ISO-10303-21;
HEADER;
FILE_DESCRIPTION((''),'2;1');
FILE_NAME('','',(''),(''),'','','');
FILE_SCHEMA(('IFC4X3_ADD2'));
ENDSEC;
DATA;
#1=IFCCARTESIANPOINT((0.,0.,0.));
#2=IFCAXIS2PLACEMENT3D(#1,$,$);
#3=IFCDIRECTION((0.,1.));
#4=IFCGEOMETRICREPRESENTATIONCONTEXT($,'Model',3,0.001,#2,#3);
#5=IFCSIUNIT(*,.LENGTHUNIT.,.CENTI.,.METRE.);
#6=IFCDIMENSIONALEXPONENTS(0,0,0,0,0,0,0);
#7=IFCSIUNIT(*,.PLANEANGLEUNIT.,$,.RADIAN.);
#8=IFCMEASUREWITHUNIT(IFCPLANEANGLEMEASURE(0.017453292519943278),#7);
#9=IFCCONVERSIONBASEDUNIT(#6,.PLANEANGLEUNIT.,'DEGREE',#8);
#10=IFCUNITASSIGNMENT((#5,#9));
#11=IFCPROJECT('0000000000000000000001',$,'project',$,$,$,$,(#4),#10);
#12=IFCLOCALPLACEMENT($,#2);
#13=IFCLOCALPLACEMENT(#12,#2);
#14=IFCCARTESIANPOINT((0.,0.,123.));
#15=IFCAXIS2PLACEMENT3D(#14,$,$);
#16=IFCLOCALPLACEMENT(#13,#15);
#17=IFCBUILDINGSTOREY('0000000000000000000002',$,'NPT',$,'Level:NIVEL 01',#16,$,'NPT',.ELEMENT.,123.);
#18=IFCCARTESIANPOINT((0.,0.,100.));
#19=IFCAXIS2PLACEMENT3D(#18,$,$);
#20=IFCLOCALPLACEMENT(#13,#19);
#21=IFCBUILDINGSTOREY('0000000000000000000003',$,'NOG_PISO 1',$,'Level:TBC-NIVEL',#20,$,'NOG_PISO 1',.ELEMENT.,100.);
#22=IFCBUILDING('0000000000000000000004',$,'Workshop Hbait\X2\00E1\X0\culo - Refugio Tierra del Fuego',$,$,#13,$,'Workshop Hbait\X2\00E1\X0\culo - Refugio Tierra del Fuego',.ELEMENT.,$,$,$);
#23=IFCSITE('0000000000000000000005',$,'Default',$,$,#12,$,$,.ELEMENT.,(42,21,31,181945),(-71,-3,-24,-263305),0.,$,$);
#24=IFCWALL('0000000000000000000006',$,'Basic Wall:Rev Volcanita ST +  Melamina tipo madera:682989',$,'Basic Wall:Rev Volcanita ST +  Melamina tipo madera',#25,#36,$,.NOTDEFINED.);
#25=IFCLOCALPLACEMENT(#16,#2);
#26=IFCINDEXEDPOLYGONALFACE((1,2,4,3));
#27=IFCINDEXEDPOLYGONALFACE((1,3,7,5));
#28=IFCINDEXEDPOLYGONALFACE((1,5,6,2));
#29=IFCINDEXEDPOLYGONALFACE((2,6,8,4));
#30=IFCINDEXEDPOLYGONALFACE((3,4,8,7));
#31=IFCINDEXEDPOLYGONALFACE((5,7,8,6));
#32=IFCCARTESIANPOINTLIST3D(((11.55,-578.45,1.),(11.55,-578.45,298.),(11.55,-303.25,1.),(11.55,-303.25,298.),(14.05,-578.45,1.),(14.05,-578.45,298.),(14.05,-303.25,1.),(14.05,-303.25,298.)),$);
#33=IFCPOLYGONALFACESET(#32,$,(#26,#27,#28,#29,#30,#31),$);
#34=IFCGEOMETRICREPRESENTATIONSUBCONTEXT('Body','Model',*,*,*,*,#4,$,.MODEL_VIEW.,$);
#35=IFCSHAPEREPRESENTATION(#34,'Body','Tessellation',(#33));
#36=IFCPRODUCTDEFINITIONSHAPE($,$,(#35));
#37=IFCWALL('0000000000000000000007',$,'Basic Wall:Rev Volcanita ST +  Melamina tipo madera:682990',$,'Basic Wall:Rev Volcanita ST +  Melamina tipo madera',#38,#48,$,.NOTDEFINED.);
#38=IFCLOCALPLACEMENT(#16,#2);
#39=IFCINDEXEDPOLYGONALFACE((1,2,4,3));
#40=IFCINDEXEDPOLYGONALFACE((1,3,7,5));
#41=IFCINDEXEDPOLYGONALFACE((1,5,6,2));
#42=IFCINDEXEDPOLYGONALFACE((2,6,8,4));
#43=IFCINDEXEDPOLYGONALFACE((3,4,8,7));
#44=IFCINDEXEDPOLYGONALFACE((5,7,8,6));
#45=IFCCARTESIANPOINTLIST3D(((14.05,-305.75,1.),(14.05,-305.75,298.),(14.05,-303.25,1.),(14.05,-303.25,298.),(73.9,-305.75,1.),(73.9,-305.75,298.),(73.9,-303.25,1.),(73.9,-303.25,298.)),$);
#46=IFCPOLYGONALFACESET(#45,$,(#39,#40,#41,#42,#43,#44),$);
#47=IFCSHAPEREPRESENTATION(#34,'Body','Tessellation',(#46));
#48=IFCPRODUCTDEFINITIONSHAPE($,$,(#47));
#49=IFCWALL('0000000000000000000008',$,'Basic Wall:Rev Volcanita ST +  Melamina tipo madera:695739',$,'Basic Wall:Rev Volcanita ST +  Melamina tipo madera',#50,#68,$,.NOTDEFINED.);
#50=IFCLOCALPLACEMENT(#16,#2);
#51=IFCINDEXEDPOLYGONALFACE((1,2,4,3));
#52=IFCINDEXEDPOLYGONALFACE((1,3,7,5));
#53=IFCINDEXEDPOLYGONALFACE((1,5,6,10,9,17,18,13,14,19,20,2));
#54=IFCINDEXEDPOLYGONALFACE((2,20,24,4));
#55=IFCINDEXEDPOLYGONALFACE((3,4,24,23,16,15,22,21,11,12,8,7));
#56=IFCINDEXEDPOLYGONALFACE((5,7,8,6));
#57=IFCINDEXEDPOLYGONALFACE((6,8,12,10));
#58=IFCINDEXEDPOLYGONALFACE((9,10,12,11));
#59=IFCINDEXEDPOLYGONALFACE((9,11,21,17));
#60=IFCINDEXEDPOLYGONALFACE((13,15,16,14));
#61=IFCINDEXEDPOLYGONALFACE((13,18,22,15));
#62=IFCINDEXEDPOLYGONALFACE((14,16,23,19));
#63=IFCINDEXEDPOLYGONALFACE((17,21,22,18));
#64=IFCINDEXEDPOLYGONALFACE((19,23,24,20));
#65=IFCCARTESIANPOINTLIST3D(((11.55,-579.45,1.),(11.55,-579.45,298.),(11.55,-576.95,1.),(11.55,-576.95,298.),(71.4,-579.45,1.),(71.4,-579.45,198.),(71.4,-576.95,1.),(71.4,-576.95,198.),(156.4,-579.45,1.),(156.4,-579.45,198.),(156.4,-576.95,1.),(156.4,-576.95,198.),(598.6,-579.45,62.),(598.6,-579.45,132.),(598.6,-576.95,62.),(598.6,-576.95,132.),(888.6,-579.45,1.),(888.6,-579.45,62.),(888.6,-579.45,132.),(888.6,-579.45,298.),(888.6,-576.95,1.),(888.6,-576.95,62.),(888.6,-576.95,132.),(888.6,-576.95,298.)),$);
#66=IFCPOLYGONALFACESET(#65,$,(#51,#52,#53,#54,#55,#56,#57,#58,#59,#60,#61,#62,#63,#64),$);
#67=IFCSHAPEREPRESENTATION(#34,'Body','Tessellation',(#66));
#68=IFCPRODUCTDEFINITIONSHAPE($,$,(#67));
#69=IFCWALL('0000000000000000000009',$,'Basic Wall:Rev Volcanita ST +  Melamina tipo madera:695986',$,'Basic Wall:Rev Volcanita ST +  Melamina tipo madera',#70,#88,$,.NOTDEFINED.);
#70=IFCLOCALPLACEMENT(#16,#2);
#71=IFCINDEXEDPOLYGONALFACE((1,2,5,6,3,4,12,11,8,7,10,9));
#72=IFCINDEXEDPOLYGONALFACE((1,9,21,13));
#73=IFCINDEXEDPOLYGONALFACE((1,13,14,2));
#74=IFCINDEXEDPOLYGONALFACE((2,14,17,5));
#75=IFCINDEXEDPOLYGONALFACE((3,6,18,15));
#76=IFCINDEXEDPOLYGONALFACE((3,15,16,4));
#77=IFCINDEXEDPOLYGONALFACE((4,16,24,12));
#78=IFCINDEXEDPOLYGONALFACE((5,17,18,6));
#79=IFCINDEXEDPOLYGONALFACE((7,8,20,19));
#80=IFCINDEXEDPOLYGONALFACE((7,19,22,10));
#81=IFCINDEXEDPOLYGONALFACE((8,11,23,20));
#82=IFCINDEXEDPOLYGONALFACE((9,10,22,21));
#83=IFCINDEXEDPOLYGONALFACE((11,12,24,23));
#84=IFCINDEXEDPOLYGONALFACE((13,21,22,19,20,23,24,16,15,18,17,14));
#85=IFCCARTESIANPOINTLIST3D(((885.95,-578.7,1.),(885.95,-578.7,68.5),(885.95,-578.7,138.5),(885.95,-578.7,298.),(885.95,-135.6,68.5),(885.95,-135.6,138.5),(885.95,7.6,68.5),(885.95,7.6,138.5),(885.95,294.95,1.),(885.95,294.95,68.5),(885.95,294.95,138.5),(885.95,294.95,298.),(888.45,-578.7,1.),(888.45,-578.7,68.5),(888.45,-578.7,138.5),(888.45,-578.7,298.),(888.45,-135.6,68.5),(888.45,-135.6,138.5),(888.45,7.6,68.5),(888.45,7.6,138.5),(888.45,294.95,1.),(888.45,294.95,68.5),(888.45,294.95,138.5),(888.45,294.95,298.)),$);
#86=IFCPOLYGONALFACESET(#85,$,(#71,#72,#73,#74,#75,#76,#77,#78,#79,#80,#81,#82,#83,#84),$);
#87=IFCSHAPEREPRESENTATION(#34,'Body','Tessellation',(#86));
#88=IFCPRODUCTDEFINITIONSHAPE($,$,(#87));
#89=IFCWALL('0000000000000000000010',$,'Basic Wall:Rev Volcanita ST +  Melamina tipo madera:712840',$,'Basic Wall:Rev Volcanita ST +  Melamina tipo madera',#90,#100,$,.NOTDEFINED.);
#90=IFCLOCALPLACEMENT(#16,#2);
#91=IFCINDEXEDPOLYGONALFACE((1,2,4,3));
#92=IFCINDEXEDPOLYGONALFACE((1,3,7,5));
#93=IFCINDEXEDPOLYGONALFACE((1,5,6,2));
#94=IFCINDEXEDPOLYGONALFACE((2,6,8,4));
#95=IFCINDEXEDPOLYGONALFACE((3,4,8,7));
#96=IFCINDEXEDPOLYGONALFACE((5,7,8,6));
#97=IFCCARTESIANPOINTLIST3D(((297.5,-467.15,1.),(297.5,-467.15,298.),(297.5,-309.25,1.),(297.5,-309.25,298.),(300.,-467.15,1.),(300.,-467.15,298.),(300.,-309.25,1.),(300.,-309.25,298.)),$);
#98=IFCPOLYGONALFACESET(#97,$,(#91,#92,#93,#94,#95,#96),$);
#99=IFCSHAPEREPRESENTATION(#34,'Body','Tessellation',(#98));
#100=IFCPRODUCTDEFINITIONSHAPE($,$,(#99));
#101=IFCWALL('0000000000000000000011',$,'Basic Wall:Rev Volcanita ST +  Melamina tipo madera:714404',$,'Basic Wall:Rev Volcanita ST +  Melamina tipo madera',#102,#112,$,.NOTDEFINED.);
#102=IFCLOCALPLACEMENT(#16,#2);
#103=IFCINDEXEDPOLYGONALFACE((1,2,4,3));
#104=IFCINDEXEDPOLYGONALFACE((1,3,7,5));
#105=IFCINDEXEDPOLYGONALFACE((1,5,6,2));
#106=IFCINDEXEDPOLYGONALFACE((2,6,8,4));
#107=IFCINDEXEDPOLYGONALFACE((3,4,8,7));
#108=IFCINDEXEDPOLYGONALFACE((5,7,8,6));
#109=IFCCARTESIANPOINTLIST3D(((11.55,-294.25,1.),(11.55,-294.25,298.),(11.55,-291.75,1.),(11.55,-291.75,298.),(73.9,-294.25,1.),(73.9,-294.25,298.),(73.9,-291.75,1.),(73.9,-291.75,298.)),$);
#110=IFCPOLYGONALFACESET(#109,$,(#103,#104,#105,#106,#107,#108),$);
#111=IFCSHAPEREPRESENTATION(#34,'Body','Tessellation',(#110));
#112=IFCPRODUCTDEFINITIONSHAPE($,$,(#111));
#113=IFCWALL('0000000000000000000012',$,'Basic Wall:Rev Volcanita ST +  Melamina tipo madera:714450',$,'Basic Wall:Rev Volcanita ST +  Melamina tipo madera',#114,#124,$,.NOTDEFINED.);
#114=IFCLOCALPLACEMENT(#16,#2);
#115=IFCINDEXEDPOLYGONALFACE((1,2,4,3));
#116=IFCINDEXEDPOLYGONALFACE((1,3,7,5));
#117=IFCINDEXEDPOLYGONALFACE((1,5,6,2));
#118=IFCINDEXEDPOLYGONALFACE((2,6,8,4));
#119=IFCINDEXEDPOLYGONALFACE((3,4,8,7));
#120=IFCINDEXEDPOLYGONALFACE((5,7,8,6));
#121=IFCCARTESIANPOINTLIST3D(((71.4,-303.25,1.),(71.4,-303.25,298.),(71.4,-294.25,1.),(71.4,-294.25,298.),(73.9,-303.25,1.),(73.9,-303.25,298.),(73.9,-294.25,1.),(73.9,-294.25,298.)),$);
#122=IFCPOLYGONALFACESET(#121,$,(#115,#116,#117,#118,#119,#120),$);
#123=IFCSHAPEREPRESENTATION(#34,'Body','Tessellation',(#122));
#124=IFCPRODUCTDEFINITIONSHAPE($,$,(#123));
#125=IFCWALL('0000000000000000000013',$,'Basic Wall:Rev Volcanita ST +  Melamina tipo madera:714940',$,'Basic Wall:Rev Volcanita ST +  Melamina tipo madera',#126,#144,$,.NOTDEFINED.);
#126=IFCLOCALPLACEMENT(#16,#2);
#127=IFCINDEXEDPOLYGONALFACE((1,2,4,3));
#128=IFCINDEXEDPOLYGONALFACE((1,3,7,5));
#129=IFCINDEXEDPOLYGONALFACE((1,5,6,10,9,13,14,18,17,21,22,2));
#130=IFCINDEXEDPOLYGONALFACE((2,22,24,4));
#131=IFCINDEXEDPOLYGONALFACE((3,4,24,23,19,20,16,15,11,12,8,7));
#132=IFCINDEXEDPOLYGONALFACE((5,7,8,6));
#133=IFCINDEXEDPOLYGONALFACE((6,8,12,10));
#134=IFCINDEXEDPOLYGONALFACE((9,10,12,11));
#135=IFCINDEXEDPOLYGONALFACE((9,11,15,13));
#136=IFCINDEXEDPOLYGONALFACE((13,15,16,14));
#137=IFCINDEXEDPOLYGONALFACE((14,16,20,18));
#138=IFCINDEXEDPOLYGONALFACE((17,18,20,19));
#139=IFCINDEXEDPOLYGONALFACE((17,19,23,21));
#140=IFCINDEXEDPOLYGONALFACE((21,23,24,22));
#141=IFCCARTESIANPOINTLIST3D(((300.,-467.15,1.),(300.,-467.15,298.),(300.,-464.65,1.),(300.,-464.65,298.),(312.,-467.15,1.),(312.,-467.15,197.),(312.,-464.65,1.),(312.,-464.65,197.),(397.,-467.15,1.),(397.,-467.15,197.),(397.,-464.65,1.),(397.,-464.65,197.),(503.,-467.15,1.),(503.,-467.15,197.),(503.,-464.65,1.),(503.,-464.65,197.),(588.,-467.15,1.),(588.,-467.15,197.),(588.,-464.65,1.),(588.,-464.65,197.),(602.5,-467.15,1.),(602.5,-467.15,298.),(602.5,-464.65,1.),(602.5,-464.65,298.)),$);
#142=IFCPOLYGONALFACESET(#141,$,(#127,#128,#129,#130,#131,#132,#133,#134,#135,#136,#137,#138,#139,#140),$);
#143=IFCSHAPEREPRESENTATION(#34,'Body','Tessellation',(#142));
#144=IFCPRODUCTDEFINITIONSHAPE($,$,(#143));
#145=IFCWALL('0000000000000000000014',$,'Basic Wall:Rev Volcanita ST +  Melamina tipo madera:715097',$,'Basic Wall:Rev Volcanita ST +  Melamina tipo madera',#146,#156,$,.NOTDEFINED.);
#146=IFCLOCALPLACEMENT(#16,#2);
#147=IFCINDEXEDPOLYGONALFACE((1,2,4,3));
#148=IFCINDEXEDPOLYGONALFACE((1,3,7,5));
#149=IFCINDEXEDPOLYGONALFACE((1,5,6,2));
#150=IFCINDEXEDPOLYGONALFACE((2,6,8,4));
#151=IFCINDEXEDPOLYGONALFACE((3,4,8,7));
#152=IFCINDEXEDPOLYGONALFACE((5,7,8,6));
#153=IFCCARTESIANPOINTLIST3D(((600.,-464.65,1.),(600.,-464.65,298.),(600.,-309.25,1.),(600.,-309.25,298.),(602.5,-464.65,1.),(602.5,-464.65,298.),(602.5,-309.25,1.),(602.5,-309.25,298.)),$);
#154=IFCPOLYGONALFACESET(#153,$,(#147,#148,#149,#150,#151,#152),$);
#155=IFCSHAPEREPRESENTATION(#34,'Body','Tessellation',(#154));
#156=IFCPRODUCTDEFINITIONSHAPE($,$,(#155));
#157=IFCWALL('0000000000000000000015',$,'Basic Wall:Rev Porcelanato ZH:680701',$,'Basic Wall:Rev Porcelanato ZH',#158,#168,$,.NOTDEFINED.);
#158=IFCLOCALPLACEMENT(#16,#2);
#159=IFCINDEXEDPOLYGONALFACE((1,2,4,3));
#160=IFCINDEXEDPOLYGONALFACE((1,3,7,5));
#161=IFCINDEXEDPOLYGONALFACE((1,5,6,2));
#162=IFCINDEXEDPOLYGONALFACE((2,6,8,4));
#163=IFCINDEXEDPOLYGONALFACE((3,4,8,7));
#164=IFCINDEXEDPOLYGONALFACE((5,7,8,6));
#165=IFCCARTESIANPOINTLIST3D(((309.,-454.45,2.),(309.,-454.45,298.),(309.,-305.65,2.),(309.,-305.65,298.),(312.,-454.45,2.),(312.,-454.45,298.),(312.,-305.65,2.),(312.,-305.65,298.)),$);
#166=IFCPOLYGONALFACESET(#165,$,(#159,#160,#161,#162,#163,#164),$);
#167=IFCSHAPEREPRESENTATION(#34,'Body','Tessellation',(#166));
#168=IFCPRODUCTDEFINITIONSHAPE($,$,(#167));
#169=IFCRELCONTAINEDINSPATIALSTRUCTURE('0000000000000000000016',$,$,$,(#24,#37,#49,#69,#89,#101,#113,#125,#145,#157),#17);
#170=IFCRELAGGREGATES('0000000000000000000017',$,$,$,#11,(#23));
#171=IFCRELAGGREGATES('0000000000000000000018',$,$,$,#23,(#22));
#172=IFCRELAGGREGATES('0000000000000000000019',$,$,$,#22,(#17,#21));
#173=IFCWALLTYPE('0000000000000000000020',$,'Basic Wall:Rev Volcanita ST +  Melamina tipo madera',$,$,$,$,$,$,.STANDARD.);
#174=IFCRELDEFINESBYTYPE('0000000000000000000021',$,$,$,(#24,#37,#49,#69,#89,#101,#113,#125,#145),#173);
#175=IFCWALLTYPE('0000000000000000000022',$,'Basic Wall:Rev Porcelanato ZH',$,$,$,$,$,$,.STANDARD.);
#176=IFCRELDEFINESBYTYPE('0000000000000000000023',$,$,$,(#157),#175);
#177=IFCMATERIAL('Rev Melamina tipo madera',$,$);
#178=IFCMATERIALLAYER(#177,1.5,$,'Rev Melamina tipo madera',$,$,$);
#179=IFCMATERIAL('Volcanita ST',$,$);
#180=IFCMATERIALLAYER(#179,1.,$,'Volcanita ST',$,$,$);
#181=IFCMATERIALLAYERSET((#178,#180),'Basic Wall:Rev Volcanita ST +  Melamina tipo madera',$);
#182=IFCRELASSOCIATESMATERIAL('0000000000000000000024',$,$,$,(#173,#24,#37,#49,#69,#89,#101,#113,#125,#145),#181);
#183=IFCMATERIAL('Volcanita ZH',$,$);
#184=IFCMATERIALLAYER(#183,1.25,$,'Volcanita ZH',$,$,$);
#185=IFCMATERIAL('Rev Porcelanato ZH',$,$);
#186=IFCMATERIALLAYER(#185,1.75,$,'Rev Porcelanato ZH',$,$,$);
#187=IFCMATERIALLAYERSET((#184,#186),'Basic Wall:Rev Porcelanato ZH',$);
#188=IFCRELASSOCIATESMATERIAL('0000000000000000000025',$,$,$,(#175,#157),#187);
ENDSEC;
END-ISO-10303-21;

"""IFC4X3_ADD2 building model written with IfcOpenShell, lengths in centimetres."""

from ifc_helpers import new_model, entity, si_unit, converted_unit, direction, frame, frame_2d, origin, place, context, subcontext, project, spatial, rectangle, extrude, material, layer, layer_set, type_object, element, save


model = new_model("IFC4X3_ADD2")

# Units and contexts
model_context = context("Model", 3, precision=0.001, world=origin(), true_north=direction((0.0, 1.0)))
body_context = subcontext(model_context, "Body", "Model", "MODEL_VIEW")
ifc_project = project(units=[si_unit("LENGTHUNIT", "METRE", prefix="CENTI"), converted_unit("PLANEANGLEUNIT", "DEGREE", entity("IfcPlaneAngleMeasure", 0.017453292519943278), si_unit("PLANEANGLEUNIT", "RADIAN"), dimensions=[0, 0, 0, 0, 0, 0, 0])], contexts=[model_context])

# Site, building, storey
site_placement = place(None, origin())
site = spatial("IfcSite", under=ifc_project, at=site_placement, Name="Default", CompositionType="ELEMENT", RefLatitude=(42, 21, 31, 181945), RefLongitude=(-71, -3, -24, -263305), RefElevation=0.0)
building_placement = place(site_placement, origin())
building = spatial("IfcBuilding", under=site, at=building_placement, Name="Workshop Hbaitáculo - Refugio Tierra del Fuego", LongName="Workshop Hbaitáculo - Refugio Tierra del Fuego", CompositionType="ELEMENT")
storey_1_placement = place(building_placement, frame((0.0, 0.0, 123.0)))
storey_1 = spatial("IfcBuildingStorey", under=building, at=storey_1_placement, Name="NPT", ObjectType="Level:NIVEL 01", LongName="NPT", CompositionType="ELEMENT", Elevation=123.0)

# Shared definitions
storey_2_placement = place(building_placement, frame((0.0, 0.0, 100.0)))
storey_2 = spatial("IfcBuildingStorey", under=building, at=storey_2_placement, Name="NOG_PISO 1", ObjectType="Level:TBC-NIVEL", LongName="NOG_PISO 1", CompositionType="ELEMENT", Elevation=100.0)

# Walls
ifc_material_1 = material(Name="Rev Melamina tipo madera")
ifc_layer_1 = layer(ifc_material_1, 1.5, Name="Rev Melamina tipo madera")
ifc_material_2 = material(Name="Volcanita ST")
ifc_layer_2 = layer(ifc_material_2, 1.0, Name="Volcanita ST")
ifc_layer_set_1 = layer_set([ifc_layer_1, ifc_layer_2], Name="Basic Wall:Rev Volcanita ST +  Melamina tipo madera")
wall_type_1 = type_object("IfcWallType", Name="Basic Wall:Rev Volcanita ST +  Melamina tipo madera", PredefinedType="STANDARD", material=ifc_layer_set_1)
wall_1_placement = place(storey_1_placement, frame((12.8, -578.45, 1.0), z_axis=(0.0, 0.0, 1.0), x_axis=(0.0, 1.0, 0.0)))
element("IfcWall", 1, at=wall_1_placement, inside=storey_1, type_object=wall_type_1, material=ifc_layer_set_1, Name="Basic Wall:Rev Volcanita ST +  Melamina tipo madera:682989", ObjectType="Basic Wall:Rev Volcanita ST +  Melamina tipo madera", PredefinedType="NOTDEFINED", context=body_context, shape_type="SweptSolid", body=[
    extrude(rectangle(XDim=275.2, YDim=2.5, at=frame_2d((137.6, 0.0), x_axis=(-1.0, 0.0))), origin(), (0.0, 0.0, 1.0), 297.0),
])
wall_2_placement = place(storey_1_placement, frame((14.05, -304.5, 1.0)))
element("IfcWall", 2, at=wall_2_placement, inside=storey_1, type_object=wall_type_1, material=ifc_layer_set_1, Name="Basic Wall:Rev Volcanita ST +  Melamina tipo madera:682990", ObjectType="Basic Wall:Rev Volcanita ST +  Melamina tipo madera", PredefinedType="NOTDEFINED", context=body_context, shape_type="SweptSolid", body=[
    extrude(rectangle(XDim=59.85, YDim=2.5, at=frame_2d((29.92, 0.0), x_axis=(-1.0, 0.0))), origin(), (0.0, 0.0, 1.0), 297.0),
])

# Walls, openings
wall_3_placement = place(storey_1_placement, frame((11.55, -578.2, 1.0)))
wall_3 = element("IfcWall", 3, at=wall_3_placement, inside=storey_1, type_object=wall_type_1, material=ifc_layer_set_1, Name="Basic Wall:Rev Volcanita ST +  Melamina tipo madera:695739", ObjectType="Basic Wall:Rev Volcanita ST +  Melamina tipo madera", PredefinedType="NOTDEFINED", context=body_context, shape_type="SweptSolid", body=[
    extrude(rectangle(XDim=877.05, YDim=2.5, at=frame_2d((438.53, 0.0), x_axis=(-1.0, 0.0))), origin(), (0.0, 0.0, 1.0), 297.0),
])
opening_1_placement = place(wall_3_placement, origin())
element("IfcOpeningElement", 4, at=opening_1_placement, cuts=wall_3, PredefinedType="OPENING", context=body_context, shape_type="SweptSolid", body=[
    extrude(rectangle(XDim=70.0, YDim=290.0, at=frame_2d((0.0, 0.0), x_axis=(1.0, 0.0))), frame((732.05, 1.25, 96.0), z_axis=(0.0, -1.0, 0.0), x_axis=(0.0, 0.0, 1.0)), (0.0, 0.0, 1.0), 2.5),
])
opening_2_placement = place(wall_3_placement, origin())
element("IfcOpeningElement", 5, at=opening_2_placement, cuts=wall_3, PredefinedType="OPENING", context=body_context, shape_type="SweptSolid", body=[
    extrude(rectangle(XDim=197.0, YDim=85.0, at=frame_2d((0.0, 0.0), x_axis=(0.0, 1.0))), frame((102.35, 1.25, 98.5), z_axis=(0.0, -1.0, 0.0), x_axis=(1.0, 0.0, 0.0)), (0.0, 0.0, 1.0), 2.5),
])
wall_4_placement = place(storey_1_placement, frame((887.2, -578.7, 1.0), z_axis=(0.0, 0.0, 1.0), x_axis=(0.0, 1.0, 0.0)))
wall_4 = element("IfcWall", 6, at=wall_4_placement, inside=storey_1, type_object=wall_type_1, material=ifc_layer_set_1, Name="Basic Wall:Rev Volcanita ST +  Melamina tipo madera:695986", ObjectType="Basic Wall:Rev Volcanita ST +  Melamina tipo madera", PredefinedType="NOTDEFINED", context=body_context, shape_type="SweptSolid", body=[
    extrude(rectangle(XDim=873.65, YDim=2.5, at=frame_2d((436.82, 0.0), x_axis=(-1.0, 0.0))), origin(), (0.0, 0.0, 1.0), 297.0),
])
opening_3_placement = place(wall_4_placement, origin())
element("IfcOpeningElement", 7, at=opening_3_placement, cuts=wall_4, PredefinedType="OPENING", context=body_context, shape_type="SweptSolid", body=[
    extrude(rectangle(XDim=70.0, YDim=288.6, at=frame_2d((0.0, 0.0), x_axis=(0.0, 1.0))), frame((730.6, 1.25, 102.5), z_axis=(0.0, -1.0, 0.0), x_axis=(-1.0, 0.0, 0.0)), (0.0, 0.0, 1.0), 2.5),
])
opening_4_placement = place(wall_4_placement, origin())
element("IfcOpeningElement", 8, at=opening_4_placement, cuts=wall_4, PredefinedType="OPENING", context=body_context, shape_type="SweptSolid", body=[
    extrude(rectangle(XDim=70.0, YDim=443.1, at=frame_2d((0.0, 0.0), x_axis=(0.0, 1.0))), frame((221.55, 1.25, 102.5), z_axis=(0.0, -1.0, 0.0), x_axis=(1.0, 0.0, 0.0)), (0.0, 0.0, 1.0), 2.5),
])

# Walls
wall_5_placement = place(storey_1_placement, frame((298.75, -309.25, 1.0), z_axis=(0.0, 0.0, 1.0), x_axis=(0.0, -1.0, 0.0)))
element("IfcWall", 9, at=wall_5_placement, inside=storey_1, type_object=wall_type_1, material=ifc_layer_set_1, Name="Basic Wall:Rev Volcanita ST +  Melamina tipo madera:712840", ObjectType="Basic Wall:Rev Volcanita ST +  Melamina tipo madera", PredefinedType="NOTDEFINED", context=body_context, shape_type="SweptSolid", body=[
    extrude(rectangle(XDim=157.9, YDim=2.5, at=frame_2d((78.95, 0.0), x_axis=(-1.0, 0.0))), origin(), (0.0, 0.0, 1.0), 297.0),
])
wall_6_placement = place(storey_1_placement, frame((11.55, -293.0, 1.0)))
element("IfcWall", 10, at=wall_6_placement, inside=storey_1, type_object=wall_type_1, material=ifc_layer_set_1, Name="Basic Wall:Rev Volcanita ST +  Melamina tipo madera:714404", ObjectType="Basic Wall:Rev Volcanita ST +  Melamina tipo madera", PredefinedType="NOTDEFINED", context=body_context, shape_type="SweptSolid", body=[
    extrude(rectangle(XDim=62.35, YDim=2.5, at=frame_2d((31.17, 0.0), x_axis=(-1.0, 0.0))), origin(), (0.0, 0.0, 1.0), 297.0),
])
wall_7_placement = place(storey_1_placement, frame((72.65, -303.25, 1.0), z_axis=(0.0, 0.0, 1.0), x_axis=(0.0, 1.0, 0.0)))
element("IfcWall", 11, at=wall_7_placement, inside=storey_1, type_object=wall_type_1, material=ifc_layer_set_1, Name="Basic Wall:Rev Volcanita ST +  Melamina tipo madera:714450", ObjectType="Basic Wall:Rev Volcanita ST +  Melamina tipo madera", PredefinedType="NOTDEFINED", context=body_context, shape_type="SweptSolid", body=[
    extrude(rectangle(XDim=9.0, YDim=2.5, at=frame_2d((4.5, 0.0), x_axis=(-1.0, 0.0))), origin(), (0.0, 0.0, 1.0), 297.0),
])

# Wall, openings
wall_8_placement = place(storey_1_placement, frame((300.0, -465.9, 1.0)))
wall_8 = element("IfcWall", 12, at=wall_8_placement, inside=storey_1, type_object=wall_type_1, material=ifc_layer_set_1, Name="Basic Wall:Rev Volcanita ST +  Melamina tipo madera:714940", ObjectType="Basic Wall:Rev Volcanita ST +  Melamina tipo madera", PredefinedType="NOTDEFINED", context=body_context, shape_type="SweptSolid", body=[
    extrude(rectangle(XDim=302.5, YDim=2.5, at=frame_2d((151.25, 0.0), x_axis=(-1.0, 0.0))), origin(), (0.0, 0.0, 1.0), 297.0),
])
opening_5_placement = place(wall_8_placement, origin())
element("IfcOpeningElement", 13, at=opening_5_placement, cuts=wall_8, PredefinedType="OPENING", context=body_context, shape_type="SweptSolid", body=[
    extrude(rectangle(XDim=196.0, YDim=85.0, at=frame_2d((0.0, 0.0), x_axis=(1.0, 0.0))), frame((245.5, 1.25, 98.0), z_axis=(0.0, -1.0, 0.0), x_axis=(0.0, 0.0, 1.0)), (0.0, 0.0, 1.0), 2.5),
])
opening_6_placement = place(wall_8_placement, origin())
element("IfcOpeningElement", 14, at=opening_6_placement, cuts=wall_8, PredefinedType="OPENING", context=body_context, shape_type="SweptSolid", body=[
    extrude(rectangle(XDim=196.0, YDim=85.0, at=frame_2d((0.0, 0.0), x_axis=(1.0, 0.0))), frame((54.5, 1.25, 98.0), z_axis=(0.0, -1.0, 0.0), x_axis=(0.0, 0.0, 1.0)), (0.0, 0.0, 1.0), 2.5),
])

# Walls
wall_9_placement = place(storey_1_placement, frame((601.25, -464.65, 1.0), z_axis=(0.0, 0.0, 1.0), x_axis=(0.0, 1.0, 0.0)))
element("IfcWall", 15, at=wall_9_placement, inside=storey_1, type_object=wall_type_1, material=ifc_layer_set_1, Name="Basic Wall:Rev Volcanita ST +  Melamina tipo madera:715097", ObjectType="Basic Wall:Rev Volcanita ST +  Melamina tipo madera", PredefinedType="NOTDEFINED", context=body_context, shape_type="SweptSolid", body=[
    extrude(rectangle(XDim=155.4, YDim=2.5, at=frame_2d((77.7, 0.0), x_axis=(-1.0, 0.0))), origin(), (0.0, 0.0, 1.0), 297.0),
])
ifc_material_3 = material(Name="Volcanita ZH")
ifc_layer_3 = layer(ifc_material_3, 1.25, Name="Volcanita ZH")
ifc_material_4 = material(Name="Rev Porcelanato ZH")
ifc_layer_4 = layer(ifc_material_4, 1.75, Name="Rev Porcelanato ZH")
ifc_layer_set_2 = layer_set([ifc_layer_3, ifc_layer_4], Name="Basic Wall:Rev Porcelanato ZH")
wall_type_2 = type_object("IfcWallType", Name="Basic Wall:Rev Porcelanato ZH", PredefinedType="STANDARD", material=ifc_layer_set_2)
wall_10_placement = place(storey_1_placement, frame((310.5, -454.45, 2.0), z_axis=(0.0, 0.0, 1.0), x_axis=(0.0, 1.0, 0.0)))
element("IfcWall", 16, at=wall_10_placement, inside=storey_1, type_object=wall_type_2, material=ifc_layer_set_2, Name="Basic Wall:Rev Porcelanato ZH:680701", ObjectType="Basic Wall:Rev Porcelanato ZH", PredefinedType="NOTDEFINED", context=body_context, shape_type="SweptSolid", body=[
    extrude(rectangle(XDim=148.8, YDim=3.0, at=frame_2d((74.4, 0.0), x_axis=(-1.0, 0.0))), origin(), (0.0, 0.0, 1.0), 296.0),
])

save(model, "model.ifc")
